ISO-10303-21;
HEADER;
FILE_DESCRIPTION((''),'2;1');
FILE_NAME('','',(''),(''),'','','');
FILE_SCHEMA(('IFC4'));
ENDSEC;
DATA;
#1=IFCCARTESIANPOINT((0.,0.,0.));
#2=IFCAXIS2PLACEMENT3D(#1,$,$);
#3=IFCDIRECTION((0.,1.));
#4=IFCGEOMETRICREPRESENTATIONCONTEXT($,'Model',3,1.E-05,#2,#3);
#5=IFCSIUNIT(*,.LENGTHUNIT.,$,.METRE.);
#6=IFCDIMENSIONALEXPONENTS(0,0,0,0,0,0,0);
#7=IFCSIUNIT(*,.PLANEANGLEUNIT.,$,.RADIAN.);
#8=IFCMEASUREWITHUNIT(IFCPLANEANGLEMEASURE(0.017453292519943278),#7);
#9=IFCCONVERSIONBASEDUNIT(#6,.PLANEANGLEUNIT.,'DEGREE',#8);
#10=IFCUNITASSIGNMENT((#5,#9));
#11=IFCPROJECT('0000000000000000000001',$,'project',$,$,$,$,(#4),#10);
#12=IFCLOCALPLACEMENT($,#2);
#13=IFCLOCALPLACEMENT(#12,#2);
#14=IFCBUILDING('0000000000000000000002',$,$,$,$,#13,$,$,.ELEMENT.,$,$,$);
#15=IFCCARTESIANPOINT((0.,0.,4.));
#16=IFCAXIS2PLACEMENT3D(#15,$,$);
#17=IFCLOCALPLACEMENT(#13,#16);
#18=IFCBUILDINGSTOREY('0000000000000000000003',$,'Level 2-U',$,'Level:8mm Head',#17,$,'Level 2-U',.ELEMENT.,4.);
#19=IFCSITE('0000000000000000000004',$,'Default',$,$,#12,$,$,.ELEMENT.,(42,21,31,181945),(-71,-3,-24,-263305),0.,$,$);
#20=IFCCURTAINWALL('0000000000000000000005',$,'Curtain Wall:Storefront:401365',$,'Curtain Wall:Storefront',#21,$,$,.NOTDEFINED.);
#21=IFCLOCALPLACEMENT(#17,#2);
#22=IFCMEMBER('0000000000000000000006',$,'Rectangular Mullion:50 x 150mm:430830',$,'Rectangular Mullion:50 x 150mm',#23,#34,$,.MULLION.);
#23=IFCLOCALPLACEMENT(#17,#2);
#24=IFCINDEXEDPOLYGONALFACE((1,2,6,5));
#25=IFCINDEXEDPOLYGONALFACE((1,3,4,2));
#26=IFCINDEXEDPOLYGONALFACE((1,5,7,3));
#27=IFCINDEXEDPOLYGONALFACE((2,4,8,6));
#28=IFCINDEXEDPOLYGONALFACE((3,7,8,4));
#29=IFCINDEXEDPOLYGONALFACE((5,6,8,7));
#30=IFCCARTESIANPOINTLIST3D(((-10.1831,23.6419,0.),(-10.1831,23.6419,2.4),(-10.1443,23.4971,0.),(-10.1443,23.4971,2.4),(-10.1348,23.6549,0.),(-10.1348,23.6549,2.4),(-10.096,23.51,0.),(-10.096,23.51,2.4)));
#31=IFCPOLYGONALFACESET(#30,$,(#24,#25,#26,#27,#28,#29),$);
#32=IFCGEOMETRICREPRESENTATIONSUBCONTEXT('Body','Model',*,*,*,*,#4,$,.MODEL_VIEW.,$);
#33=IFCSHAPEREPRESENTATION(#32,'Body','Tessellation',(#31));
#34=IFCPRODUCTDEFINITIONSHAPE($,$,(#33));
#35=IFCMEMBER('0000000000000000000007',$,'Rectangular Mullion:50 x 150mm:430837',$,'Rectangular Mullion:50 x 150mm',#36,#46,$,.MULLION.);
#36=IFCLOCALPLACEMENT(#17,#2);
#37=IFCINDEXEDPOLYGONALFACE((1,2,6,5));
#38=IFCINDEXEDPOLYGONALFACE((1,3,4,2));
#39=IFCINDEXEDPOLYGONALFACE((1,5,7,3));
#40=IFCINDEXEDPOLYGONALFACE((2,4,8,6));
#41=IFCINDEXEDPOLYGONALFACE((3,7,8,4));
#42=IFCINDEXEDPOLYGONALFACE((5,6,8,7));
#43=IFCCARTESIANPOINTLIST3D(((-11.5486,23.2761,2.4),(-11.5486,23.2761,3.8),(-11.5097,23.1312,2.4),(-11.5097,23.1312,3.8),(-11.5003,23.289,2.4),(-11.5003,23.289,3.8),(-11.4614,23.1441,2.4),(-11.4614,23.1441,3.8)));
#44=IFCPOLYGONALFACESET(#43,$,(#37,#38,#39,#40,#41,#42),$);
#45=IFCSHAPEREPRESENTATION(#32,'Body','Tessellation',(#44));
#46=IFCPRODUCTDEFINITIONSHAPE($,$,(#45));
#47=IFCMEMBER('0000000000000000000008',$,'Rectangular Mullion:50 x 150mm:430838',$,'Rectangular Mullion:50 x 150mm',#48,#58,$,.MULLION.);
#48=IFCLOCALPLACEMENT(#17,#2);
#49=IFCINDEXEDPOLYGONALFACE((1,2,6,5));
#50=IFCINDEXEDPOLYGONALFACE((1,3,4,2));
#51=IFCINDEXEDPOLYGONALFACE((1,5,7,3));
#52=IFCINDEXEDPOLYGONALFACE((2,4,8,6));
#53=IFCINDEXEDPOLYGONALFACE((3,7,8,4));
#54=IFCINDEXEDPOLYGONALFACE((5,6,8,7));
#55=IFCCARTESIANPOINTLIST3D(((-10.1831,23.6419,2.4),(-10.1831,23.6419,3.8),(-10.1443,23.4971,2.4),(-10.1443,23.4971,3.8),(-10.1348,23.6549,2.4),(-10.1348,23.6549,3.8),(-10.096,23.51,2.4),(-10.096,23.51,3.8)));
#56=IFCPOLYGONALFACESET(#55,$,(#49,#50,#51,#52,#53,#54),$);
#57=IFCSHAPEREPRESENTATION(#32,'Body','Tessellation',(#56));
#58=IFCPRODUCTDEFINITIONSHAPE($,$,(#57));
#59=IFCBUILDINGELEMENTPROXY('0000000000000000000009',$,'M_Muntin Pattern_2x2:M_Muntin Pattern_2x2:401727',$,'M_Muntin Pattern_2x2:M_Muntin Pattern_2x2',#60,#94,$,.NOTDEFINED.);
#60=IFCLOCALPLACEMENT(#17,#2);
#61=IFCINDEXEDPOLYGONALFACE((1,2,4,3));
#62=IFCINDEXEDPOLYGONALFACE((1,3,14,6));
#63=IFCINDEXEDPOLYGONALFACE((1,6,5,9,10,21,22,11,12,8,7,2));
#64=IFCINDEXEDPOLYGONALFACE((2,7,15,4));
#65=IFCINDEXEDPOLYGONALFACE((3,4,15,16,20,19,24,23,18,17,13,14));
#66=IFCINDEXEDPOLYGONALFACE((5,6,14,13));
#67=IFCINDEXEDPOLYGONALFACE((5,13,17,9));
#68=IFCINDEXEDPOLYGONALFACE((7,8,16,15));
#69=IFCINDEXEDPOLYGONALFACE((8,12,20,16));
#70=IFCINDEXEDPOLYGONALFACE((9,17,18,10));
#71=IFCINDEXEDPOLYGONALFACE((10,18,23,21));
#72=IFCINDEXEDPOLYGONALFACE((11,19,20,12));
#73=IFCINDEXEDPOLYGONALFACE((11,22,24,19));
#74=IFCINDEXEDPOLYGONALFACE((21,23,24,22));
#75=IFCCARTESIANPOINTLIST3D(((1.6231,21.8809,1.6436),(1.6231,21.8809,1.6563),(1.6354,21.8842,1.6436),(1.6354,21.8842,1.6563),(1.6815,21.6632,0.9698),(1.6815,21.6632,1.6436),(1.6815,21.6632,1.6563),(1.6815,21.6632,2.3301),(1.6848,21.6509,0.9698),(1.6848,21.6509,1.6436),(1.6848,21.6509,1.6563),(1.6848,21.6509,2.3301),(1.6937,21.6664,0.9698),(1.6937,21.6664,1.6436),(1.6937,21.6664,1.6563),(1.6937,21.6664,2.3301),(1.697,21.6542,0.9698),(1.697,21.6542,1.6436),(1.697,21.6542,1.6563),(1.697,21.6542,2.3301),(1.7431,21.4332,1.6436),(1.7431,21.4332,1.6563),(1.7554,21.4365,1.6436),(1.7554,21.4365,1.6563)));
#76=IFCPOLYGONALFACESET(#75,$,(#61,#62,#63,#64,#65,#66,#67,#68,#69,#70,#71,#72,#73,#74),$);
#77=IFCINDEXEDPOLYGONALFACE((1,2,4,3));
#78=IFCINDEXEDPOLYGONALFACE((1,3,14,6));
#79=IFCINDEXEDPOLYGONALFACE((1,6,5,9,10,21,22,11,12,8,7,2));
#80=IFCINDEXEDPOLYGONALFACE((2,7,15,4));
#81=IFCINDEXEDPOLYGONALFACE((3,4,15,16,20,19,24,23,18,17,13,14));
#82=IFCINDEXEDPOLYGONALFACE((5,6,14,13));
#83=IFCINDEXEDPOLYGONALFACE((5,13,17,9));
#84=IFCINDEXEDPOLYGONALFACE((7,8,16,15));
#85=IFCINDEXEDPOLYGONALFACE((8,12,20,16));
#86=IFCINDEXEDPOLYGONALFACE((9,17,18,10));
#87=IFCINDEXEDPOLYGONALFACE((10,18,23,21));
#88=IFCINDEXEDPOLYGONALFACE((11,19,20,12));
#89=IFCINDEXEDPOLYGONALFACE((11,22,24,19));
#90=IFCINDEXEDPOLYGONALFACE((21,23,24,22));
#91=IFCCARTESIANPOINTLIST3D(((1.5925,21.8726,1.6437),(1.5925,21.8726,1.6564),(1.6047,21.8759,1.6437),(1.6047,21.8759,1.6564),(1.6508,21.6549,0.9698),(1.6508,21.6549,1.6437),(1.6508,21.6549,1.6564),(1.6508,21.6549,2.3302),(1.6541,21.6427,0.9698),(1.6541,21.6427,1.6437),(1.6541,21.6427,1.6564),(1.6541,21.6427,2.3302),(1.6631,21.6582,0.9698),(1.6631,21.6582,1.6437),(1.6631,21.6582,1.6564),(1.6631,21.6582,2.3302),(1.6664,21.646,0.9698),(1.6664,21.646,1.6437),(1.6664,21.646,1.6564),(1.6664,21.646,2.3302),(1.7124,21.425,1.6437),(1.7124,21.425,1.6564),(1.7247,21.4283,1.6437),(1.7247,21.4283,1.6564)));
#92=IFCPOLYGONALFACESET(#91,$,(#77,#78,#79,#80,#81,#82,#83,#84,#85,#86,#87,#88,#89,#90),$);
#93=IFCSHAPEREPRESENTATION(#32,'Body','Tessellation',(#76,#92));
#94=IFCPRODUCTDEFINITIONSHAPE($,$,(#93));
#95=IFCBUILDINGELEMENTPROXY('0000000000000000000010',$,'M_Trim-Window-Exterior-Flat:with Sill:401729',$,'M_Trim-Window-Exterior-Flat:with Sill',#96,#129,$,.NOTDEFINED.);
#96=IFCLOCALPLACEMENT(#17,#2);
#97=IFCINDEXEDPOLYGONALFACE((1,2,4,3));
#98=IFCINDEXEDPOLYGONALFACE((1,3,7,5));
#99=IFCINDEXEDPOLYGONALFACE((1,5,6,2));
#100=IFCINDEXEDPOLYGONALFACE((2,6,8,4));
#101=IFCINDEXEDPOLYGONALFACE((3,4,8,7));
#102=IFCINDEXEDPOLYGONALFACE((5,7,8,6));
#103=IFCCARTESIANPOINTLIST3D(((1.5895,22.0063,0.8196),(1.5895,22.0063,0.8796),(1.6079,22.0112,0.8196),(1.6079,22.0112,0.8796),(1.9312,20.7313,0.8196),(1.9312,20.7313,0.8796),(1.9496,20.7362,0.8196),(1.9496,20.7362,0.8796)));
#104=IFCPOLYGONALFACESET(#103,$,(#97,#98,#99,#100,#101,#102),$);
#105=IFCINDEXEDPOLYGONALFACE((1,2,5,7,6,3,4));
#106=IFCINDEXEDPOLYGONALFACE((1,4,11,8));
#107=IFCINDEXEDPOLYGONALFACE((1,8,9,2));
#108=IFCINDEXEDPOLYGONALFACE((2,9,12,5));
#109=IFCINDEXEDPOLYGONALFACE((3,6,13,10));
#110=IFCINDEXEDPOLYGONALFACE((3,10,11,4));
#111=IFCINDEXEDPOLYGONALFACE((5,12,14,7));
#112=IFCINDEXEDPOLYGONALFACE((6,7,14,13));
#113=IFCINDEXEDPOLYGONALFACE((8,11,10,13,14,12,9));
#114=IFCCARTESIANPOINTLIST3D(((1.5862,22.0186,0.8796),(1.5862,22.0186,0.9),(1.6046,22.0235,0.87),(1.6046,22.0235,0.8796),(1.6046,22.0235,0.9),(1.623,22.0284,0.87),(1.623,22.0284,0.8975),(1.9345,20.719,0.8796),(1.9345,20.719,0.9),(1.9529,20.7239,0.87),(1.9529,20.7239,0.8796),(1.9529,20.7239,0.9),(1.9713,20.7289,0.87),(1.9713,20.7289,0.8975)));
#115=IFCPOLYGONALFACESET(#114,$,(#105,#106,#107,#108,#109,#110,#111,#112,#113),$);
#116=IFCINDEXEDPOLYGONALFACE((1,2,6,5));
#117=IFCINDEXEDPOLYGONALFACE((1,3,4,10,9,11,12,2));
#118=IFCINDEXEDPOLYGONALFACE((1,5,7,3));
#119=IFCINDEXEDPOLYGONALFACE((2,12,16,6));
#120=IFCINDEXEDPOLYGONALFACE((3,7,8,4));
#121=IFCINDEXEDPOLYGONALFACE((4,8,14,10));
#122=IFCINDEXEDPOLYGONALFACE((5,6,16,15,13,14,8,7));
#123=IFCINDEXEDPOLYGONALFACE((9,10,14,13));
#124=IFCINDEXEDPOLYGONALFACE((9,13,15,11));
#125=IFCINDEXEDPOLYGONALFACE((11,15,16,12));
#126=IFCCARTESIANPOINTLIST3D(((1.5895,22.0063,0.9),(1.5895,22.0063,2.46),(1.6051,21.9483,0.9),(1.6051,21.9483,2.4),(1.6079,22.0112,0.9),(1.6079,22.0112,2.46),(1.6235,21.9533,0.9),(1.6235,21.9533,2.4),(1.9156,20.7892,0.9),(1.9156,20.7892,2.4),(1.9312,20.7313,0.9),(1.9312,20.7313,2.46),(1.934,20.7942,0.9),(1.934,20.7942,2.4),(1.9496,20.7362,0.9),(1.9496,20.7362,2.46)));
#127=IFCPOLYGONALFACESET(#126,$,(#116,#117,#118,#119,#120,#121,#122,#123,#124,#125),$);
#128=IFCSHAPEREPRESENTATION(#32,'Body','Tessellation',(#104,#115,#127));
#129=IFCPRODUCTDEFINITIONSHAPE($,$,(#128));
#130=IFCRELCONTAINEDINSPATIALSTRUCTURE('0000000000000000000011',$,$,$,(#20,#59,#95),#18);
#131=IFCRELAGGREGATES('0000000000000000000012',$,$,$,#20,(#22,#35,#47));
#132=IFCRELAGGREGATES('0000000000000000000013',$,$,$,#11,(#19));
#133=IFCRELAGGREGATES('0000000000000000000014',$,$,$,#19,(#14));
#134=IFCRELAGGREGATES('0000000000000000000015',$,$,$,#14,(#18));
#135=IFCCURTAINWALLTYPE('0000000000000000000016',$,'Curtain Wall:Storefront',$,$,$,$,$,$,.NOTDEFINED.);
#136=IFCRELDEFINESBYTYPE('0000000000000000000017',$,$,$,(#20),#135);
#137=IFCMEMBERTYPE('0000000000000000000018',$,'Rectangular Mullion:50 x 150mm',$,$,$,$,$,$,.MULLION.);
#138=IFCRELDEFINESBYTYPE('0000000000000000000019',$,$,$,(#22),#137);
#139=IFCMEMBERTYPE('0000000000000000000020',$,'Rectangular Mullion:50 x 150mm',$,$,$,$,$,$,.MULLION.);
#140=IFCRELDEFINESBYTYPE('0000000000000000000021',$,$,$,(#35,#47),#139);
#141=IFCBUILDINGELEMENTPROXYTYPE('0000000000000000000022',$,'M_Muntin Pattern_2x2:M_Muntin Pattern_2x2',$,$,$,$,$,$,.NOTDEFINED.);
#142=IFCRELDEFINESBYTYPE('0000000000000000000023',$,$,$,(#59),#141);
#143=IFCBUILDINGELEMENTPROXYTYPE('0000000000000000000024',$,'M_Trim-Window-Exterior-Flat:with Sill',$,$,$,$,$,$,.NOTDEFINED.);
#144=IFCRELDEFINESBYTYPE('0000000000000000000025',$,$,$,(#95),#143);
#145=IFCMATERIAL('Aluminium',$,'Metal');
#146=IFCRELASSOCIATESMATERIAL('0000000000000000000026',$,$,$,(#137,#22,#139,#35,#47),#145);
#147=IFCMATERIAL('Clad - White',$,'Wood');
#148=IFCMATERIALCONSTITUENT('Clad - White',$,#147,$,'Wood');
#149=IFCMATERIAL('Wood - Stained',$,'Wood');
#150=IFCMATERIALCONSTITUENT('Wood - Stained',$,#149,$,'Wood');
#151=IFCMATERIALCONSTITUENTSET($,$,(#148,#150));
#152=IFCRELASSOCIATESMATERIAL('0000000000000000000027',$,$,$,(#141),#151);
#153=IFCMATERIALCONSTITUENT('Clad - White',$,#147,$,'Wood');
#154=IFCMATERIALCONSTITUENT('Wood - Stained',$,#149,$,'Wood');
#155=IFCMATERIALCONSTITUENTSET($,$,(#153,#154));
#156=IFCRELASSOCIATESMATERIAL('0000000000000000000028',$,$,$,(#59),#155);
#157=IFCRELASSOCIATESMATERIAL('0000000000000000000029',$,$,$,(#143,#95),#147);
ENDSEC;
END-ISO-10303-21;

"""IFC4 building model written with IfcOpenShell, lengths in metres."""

from ifc_helpers import new_model, entity, si_unit, converted_unit, direction, frame, origin, place, context, subcontext, project, spatial, indexed_curve, outline, extrude, source, transform, mapped, material, constituent, constituent_set, type_object, type_shapes, element, aggregate, save


model = new_model("IFC4")

# Units and contexts
model_context = context("Model", 3, precision=1e-05, world=origin(), true_north=direction((0.0, 1.0)))
body_context = subcontext(model_context, "Body", "Model", "MODEL_VIEW")
ifc_project = project(units=[si_unit("LENGTHUNIT", "METRE"), converted_unit("PLANEANGLEUNIT", "DEGREE", entity("IfcPlaneAngleMeasure", 0.017453292519943278), si_unit("PLANEANGLEUNIT", "RADIAN"), dimensions=[0, 0, 0, 0, 0, 0, 0])], contexts=[model_context])

# Site, building, storey
site_placement = place(None, origin())
site = spatial("IfcSite", under=ifc_project, at=site_placement, Name="Default", CompositionType="ELEMENT", RefLatitude=(42, 21, 31, 181945), RefLongitude=(-71, -3, -24, -263305), RefElevation=0.0)
building_placement = place(site_placement, origin())
building = spatial("IfcBuilding", under=site, at=building_placement, CompositionType="ELEMENT")
storey_placement = place(building_placement, frame((0.0, 0.0, 4.0)))
storey = spatial("IfcBuildingStorey", under=building, at=storey_placement, Name="Level 2-U", ObjectType="Level:8mm Head", LongName="Level 2-U", CompositionType="ELEMENT", Elevation=4.0)

# Curtain wall, members
curtain_wall_type = type_object("IfcCurtainWallType", Name="Curtain Wall:Storefront", PredefinedType="NOTDEFINED")
curtain_wall_placement = place(storey_placement, frame((0.0, 0.0, -4.0)))
curtain_wall = element("IfcCurtainWall", 1, at=curtain_wall_placement, inside=storey, type_object=curtain_wall_type, Name="Curtain Wall:Storefront:401365", ObjectType="Curtain Wall:Storefront", PredefinedType="NOTDEFINED")
ifc_material_1 = material(Name="Aluminium", Category="Metal")
member_type_1 = type_object("IfcMemberType", Name="Rectangular Mullion:50 x 150mm", PredefinedType="MULLION", material=ifc_material_1)
shared_shape_1 = source(origin(), body_context, "Body", "SweptSolid", [
    extrude(outline(indexed_curve([(-0.025, -0.075), (0.025, -0.075), (0.025, 0.075), (-0.025, 0.075), (-0.025, -0.075)], self_intersect=False)), frame((0.0, 0.0, -2.4), z_axis=(0.0, 0.0, 1.0), x_axis=(-1.0, 0.0, 0.0)), (0.0, 0.0, 1.0), 2.4),
])
type_shapes(member_type_1, [shared_shape_1])
member_1_placement = place(curtain_wall_placement, frame((-10.1395, 23.576, 4.0), z_axis=(0.0, 0.0, -1.0), x_axis=(0.965926, 0.258819, 0.0)))
member_1 = element("IfcMember", 2, at=member_1_placement, type_object=member_type_1, material=ifc_material_1, Name="Rectangular Mullion:50 x 150mm:430830", ObjectType="Rectangular Mullion:50 x 150mm", PredefinedType="MULLION", context=body_context, shape_type="MappedRepresentation", body=[
    mapped(shared_shape_1, transform((0.0, 0.0, 0.0), scale=1.0)),
])
member_type_2 = type_object("IfcMemberType", Name="Rectangular Mullion:50 x 150mm", PredefinedType="MULLION", material=ifc_material_1)
shared_shape_2 = source(origin(), body_context, "Body", "SweptSolid", [
    extrude(outline(indexed_curve([(-0.025, -0.075), (0.025, -0.075), (0.025, 0.075), (-0.025, 0.075), (-0.025, -0.075)], self_intersect=False)), frame((0.0, 0.0, -1.4), z_axis=(0.0, 0.0, 1.0), x_axis=(-1.0, 0.0, 0.0)), (0.0, 0.0, 1.0), 1.4),
])
type_shapes(member_type_2, [shared_shape_2])
member_2_placement = place(curtain_wall_placement, frame((-11.505, 23.2101, 6.4), z_axis=(0.0, 0.0, -1.0), x_axis=(0.965926, 0.258819, 0.0)))
member_2 = element("IfcMember", 3, at=member_2_placement, type_object=member_type_2, material=ifc_material_1, Name="Rectangular Mullion:50 x 150mm:430837", ObjectType="Rectangular Mullion:50 x 150mm", PredefinedType="MULLION", context=body_context, shape_type="MappedRepresentation", body=[
    mapped(shared_shape_2, transform((0.0, 0.0, 0.0), scale=1.0)),
])
member_3_placement = place(curtain_wall_placement, frame((-10.1395, 23.576, 6.4), z_axis=(0.0, 0.0, -1.0), x_axis=(0.965926, 0.258819, 0.0)))
member_3 = element("IfcMember", 4, at=member_3_placement, type_object=member_type_2, material=ifc_material_1, Name="Rectangular Mullion:50 x 150mm:430838", ObjectType="Rectangular Mullion:50 x 150mm", PredefinedType="MULLION", context=body_context, shape_type="MappedRepresentation", body=[
    mapped(shared_shape_2, transform((0.0, 0.0, 0.0), scale=1.0)),
])
aggregate(curtain_wall, [member_1, member_2, member_3])

# Building element proxies
ifc_material_2 = material(Name="Clad - White", Category="Wood")
ifc_constituent_1 = constituent(ifc_material_2, Name="Clad - White", Category="Wood")
ifc_material_3 = material(Name="Wood - Stained", Category="Wood")
ifc_constituent_2 = constituent(ifc_material_3, Name="Wood - Stained", Category="Wood")
ifc_constituent_set_1 = constituent_set(constituents=[ifc_constituent_1, ifc_constituent_2])
ifc_constituent_3 = constituent(ifc_material_2, Name="Clad - White", Category="Wood")
ifc_constituent_4 = constituent(ifc_material_3, Name="Wood - Stained", Category="Wood")
ifc_constituent_set_2 = constituent_set(constituents=[ifc_constituent_3, ifc_constituent_4])
building_element_proxy_type_1 = type_object("IfcBuildingElementProxyType", Name="M_Muntin Pattern_2x2:M_Muntin Pattern_2x2", PredefinedType="NOTDEFINED", material=ifc_constituent_set_2)
shared_shape_3 = source(origin(), body_context, "Body", "SweptSolid", [
    extrude(outline(indexed_curve([(0.0064, -0.0064), (0.6801, -0.0064), (0.6801, 0.0063), (0.0064, 0.0063), (0.0064, 0.2317), (-0.0063, 0.2317), (-0.0063, 0.0063), (-0.6802, 0.0063), (-0.6802, -0.0064), (-0.0063, -0.0064), (-0.0063, -0.2317), (0.0064, -0.2317), (0.0064, -0.0064)], self_intersect=False)), frame((0.0, 0.0095, 0.6801), z_axis=(0.0, 1.0, 0.0), x_axis=(0.0, 0.0, 1.0)), (0.0, 0.0, 1.0), 0.0127),
    extrude(outline(indexed_curve([(0.0064, -0.0064), (0.6802, -0.0064), (0.6802, 0.0063), (0.0064, 0.0063), (0.0064, 0.2317), (-0.0063, 0.2317), (-0.0063, 0.0063), (-0.6802, 0.0063), (-0.6802, -0.0064), (-0.0063, -0.0064), (-0.0063, -0.2317), (0.0064, -0.2317), (0.0064, -0.0064)], self_intersect=False)), frame((0.0, -0.0222, 0.6802), z_axis=(0.0, 1.0, 0.0), x_axis=(0.0, 0.0, 1.0)), (0.0, 0.0, 1.0), 0.0127),
])
type_shapes(building_element_proxy_type_1, [shared_shape_3])
proxy_1_placement = place(storey_placement, frame((1.6739, 21.6546, 0.9698), z_axis=(0.0, 0.0, 1.0), x_axis=(0.258819, -0.965926, 0.0)))
element("IfcBuildingElementProxy", 5, at=proxy_1_placement, inside=storey, type_object=building_element_proxy_type_1, material=ifc_constituent_set_1, Name="M_Muntin Pattern_2x2:M_Muntin Pattern_2x2:401727", ObjectType="M_Muntin Pattern_2x2:M_Muntin Pattern_2x2", PredefinedType="NOTDEFINED", context=body_context, shape_type="MappedRepresentation", body=[
    mapped(shared_shape_3, transform((0.0, 0.0, 0.0), scale=1.0)),
])
building_element_proxy_type_2 = type_object("IfcBuildingElementProxyType", Name="M_Trim-Window-Exterior-Flat:with Sill", PredefinedType="NOTDEFINED", material=ifc_material_2)
shared_shape_4 = source(origin(), body_context, "Body", "SweptSolid", [
    extrude(outline(indexed_curve([(-0.66, -0.03), (0.66, -0.03), (0.66, 0.03), (-0.66, 0.03), (-0.66, -0.03)], self_intersect=False)), frame((0.0, -1.5504, 0.0), z_axis=(0.0, 0.0, 1.0), x_axis=(-1.0, 0.0, 0.0)), (0.0, 0.0, 1.0), 0.019),
    extrude(outline(indexed_curve([(-0.019, -0.0152), (0.0, -0.0152), (0.0, -0.0057), (0.019, -0.0057), (0.019, 0.0148), (0.0, 0.0148), (-0.019, 0.0123), (-0.019, -0.0152)], self_intersect=False)), frame((-0.6727, -1.5148, 0.019), z_axis=(1.0, 0.0, 0.0), x_axis=(0.0, 0.0, -1.0)), (0.0, 0.0, 1.0), 1.3454),
    extrude(outline(indexed_curve([(-0.795, -0.66), (0.765, -0.66), (0.765, -0.6), (-0.735, -0.6), (-0.735, 0.6), (0.765, 0.6), (0.765, 0.66), (-0.795, 0.66), (-0.795, -0.66)], self_intersect=False)), frame((0.0, -0.735, 0.0), z_axis=(0.0, 0.0, 1.0), x_axis=(0.0, -1.0, 0.0)), (0.0, 0.0, 1.0), 0.019),
])
type_shapes(building_element_proxy_type_2, [shared_shape_4])
proxy_2_placement = place(storey_placement, frame((1.7603, 21.3688, 2.4), z_axis=(0.965926, 0.258819, 0.0), x_axis=(-0.258819, 0.965926, 0.0)))
element("IfcBuildingElementProxy", 6, at=proxy_2_placement, inside=storey, type_object=building_element_proxy_type_2, material=ifc_material_2, Name="M_Trim-Window-Exterior-Flat:with Sill:401729", ObjectType="M_Trim-Window-Exterior-Flat:with Sill", PredefinedType="NOTDEFINED", context=body_context, shape_type="MappedRepresentation", body=[
    mapped(shared_shape_4, transform((0.0, 0.0, 0.0), scale=1.0)),
])

save(model, "model.ifc")
